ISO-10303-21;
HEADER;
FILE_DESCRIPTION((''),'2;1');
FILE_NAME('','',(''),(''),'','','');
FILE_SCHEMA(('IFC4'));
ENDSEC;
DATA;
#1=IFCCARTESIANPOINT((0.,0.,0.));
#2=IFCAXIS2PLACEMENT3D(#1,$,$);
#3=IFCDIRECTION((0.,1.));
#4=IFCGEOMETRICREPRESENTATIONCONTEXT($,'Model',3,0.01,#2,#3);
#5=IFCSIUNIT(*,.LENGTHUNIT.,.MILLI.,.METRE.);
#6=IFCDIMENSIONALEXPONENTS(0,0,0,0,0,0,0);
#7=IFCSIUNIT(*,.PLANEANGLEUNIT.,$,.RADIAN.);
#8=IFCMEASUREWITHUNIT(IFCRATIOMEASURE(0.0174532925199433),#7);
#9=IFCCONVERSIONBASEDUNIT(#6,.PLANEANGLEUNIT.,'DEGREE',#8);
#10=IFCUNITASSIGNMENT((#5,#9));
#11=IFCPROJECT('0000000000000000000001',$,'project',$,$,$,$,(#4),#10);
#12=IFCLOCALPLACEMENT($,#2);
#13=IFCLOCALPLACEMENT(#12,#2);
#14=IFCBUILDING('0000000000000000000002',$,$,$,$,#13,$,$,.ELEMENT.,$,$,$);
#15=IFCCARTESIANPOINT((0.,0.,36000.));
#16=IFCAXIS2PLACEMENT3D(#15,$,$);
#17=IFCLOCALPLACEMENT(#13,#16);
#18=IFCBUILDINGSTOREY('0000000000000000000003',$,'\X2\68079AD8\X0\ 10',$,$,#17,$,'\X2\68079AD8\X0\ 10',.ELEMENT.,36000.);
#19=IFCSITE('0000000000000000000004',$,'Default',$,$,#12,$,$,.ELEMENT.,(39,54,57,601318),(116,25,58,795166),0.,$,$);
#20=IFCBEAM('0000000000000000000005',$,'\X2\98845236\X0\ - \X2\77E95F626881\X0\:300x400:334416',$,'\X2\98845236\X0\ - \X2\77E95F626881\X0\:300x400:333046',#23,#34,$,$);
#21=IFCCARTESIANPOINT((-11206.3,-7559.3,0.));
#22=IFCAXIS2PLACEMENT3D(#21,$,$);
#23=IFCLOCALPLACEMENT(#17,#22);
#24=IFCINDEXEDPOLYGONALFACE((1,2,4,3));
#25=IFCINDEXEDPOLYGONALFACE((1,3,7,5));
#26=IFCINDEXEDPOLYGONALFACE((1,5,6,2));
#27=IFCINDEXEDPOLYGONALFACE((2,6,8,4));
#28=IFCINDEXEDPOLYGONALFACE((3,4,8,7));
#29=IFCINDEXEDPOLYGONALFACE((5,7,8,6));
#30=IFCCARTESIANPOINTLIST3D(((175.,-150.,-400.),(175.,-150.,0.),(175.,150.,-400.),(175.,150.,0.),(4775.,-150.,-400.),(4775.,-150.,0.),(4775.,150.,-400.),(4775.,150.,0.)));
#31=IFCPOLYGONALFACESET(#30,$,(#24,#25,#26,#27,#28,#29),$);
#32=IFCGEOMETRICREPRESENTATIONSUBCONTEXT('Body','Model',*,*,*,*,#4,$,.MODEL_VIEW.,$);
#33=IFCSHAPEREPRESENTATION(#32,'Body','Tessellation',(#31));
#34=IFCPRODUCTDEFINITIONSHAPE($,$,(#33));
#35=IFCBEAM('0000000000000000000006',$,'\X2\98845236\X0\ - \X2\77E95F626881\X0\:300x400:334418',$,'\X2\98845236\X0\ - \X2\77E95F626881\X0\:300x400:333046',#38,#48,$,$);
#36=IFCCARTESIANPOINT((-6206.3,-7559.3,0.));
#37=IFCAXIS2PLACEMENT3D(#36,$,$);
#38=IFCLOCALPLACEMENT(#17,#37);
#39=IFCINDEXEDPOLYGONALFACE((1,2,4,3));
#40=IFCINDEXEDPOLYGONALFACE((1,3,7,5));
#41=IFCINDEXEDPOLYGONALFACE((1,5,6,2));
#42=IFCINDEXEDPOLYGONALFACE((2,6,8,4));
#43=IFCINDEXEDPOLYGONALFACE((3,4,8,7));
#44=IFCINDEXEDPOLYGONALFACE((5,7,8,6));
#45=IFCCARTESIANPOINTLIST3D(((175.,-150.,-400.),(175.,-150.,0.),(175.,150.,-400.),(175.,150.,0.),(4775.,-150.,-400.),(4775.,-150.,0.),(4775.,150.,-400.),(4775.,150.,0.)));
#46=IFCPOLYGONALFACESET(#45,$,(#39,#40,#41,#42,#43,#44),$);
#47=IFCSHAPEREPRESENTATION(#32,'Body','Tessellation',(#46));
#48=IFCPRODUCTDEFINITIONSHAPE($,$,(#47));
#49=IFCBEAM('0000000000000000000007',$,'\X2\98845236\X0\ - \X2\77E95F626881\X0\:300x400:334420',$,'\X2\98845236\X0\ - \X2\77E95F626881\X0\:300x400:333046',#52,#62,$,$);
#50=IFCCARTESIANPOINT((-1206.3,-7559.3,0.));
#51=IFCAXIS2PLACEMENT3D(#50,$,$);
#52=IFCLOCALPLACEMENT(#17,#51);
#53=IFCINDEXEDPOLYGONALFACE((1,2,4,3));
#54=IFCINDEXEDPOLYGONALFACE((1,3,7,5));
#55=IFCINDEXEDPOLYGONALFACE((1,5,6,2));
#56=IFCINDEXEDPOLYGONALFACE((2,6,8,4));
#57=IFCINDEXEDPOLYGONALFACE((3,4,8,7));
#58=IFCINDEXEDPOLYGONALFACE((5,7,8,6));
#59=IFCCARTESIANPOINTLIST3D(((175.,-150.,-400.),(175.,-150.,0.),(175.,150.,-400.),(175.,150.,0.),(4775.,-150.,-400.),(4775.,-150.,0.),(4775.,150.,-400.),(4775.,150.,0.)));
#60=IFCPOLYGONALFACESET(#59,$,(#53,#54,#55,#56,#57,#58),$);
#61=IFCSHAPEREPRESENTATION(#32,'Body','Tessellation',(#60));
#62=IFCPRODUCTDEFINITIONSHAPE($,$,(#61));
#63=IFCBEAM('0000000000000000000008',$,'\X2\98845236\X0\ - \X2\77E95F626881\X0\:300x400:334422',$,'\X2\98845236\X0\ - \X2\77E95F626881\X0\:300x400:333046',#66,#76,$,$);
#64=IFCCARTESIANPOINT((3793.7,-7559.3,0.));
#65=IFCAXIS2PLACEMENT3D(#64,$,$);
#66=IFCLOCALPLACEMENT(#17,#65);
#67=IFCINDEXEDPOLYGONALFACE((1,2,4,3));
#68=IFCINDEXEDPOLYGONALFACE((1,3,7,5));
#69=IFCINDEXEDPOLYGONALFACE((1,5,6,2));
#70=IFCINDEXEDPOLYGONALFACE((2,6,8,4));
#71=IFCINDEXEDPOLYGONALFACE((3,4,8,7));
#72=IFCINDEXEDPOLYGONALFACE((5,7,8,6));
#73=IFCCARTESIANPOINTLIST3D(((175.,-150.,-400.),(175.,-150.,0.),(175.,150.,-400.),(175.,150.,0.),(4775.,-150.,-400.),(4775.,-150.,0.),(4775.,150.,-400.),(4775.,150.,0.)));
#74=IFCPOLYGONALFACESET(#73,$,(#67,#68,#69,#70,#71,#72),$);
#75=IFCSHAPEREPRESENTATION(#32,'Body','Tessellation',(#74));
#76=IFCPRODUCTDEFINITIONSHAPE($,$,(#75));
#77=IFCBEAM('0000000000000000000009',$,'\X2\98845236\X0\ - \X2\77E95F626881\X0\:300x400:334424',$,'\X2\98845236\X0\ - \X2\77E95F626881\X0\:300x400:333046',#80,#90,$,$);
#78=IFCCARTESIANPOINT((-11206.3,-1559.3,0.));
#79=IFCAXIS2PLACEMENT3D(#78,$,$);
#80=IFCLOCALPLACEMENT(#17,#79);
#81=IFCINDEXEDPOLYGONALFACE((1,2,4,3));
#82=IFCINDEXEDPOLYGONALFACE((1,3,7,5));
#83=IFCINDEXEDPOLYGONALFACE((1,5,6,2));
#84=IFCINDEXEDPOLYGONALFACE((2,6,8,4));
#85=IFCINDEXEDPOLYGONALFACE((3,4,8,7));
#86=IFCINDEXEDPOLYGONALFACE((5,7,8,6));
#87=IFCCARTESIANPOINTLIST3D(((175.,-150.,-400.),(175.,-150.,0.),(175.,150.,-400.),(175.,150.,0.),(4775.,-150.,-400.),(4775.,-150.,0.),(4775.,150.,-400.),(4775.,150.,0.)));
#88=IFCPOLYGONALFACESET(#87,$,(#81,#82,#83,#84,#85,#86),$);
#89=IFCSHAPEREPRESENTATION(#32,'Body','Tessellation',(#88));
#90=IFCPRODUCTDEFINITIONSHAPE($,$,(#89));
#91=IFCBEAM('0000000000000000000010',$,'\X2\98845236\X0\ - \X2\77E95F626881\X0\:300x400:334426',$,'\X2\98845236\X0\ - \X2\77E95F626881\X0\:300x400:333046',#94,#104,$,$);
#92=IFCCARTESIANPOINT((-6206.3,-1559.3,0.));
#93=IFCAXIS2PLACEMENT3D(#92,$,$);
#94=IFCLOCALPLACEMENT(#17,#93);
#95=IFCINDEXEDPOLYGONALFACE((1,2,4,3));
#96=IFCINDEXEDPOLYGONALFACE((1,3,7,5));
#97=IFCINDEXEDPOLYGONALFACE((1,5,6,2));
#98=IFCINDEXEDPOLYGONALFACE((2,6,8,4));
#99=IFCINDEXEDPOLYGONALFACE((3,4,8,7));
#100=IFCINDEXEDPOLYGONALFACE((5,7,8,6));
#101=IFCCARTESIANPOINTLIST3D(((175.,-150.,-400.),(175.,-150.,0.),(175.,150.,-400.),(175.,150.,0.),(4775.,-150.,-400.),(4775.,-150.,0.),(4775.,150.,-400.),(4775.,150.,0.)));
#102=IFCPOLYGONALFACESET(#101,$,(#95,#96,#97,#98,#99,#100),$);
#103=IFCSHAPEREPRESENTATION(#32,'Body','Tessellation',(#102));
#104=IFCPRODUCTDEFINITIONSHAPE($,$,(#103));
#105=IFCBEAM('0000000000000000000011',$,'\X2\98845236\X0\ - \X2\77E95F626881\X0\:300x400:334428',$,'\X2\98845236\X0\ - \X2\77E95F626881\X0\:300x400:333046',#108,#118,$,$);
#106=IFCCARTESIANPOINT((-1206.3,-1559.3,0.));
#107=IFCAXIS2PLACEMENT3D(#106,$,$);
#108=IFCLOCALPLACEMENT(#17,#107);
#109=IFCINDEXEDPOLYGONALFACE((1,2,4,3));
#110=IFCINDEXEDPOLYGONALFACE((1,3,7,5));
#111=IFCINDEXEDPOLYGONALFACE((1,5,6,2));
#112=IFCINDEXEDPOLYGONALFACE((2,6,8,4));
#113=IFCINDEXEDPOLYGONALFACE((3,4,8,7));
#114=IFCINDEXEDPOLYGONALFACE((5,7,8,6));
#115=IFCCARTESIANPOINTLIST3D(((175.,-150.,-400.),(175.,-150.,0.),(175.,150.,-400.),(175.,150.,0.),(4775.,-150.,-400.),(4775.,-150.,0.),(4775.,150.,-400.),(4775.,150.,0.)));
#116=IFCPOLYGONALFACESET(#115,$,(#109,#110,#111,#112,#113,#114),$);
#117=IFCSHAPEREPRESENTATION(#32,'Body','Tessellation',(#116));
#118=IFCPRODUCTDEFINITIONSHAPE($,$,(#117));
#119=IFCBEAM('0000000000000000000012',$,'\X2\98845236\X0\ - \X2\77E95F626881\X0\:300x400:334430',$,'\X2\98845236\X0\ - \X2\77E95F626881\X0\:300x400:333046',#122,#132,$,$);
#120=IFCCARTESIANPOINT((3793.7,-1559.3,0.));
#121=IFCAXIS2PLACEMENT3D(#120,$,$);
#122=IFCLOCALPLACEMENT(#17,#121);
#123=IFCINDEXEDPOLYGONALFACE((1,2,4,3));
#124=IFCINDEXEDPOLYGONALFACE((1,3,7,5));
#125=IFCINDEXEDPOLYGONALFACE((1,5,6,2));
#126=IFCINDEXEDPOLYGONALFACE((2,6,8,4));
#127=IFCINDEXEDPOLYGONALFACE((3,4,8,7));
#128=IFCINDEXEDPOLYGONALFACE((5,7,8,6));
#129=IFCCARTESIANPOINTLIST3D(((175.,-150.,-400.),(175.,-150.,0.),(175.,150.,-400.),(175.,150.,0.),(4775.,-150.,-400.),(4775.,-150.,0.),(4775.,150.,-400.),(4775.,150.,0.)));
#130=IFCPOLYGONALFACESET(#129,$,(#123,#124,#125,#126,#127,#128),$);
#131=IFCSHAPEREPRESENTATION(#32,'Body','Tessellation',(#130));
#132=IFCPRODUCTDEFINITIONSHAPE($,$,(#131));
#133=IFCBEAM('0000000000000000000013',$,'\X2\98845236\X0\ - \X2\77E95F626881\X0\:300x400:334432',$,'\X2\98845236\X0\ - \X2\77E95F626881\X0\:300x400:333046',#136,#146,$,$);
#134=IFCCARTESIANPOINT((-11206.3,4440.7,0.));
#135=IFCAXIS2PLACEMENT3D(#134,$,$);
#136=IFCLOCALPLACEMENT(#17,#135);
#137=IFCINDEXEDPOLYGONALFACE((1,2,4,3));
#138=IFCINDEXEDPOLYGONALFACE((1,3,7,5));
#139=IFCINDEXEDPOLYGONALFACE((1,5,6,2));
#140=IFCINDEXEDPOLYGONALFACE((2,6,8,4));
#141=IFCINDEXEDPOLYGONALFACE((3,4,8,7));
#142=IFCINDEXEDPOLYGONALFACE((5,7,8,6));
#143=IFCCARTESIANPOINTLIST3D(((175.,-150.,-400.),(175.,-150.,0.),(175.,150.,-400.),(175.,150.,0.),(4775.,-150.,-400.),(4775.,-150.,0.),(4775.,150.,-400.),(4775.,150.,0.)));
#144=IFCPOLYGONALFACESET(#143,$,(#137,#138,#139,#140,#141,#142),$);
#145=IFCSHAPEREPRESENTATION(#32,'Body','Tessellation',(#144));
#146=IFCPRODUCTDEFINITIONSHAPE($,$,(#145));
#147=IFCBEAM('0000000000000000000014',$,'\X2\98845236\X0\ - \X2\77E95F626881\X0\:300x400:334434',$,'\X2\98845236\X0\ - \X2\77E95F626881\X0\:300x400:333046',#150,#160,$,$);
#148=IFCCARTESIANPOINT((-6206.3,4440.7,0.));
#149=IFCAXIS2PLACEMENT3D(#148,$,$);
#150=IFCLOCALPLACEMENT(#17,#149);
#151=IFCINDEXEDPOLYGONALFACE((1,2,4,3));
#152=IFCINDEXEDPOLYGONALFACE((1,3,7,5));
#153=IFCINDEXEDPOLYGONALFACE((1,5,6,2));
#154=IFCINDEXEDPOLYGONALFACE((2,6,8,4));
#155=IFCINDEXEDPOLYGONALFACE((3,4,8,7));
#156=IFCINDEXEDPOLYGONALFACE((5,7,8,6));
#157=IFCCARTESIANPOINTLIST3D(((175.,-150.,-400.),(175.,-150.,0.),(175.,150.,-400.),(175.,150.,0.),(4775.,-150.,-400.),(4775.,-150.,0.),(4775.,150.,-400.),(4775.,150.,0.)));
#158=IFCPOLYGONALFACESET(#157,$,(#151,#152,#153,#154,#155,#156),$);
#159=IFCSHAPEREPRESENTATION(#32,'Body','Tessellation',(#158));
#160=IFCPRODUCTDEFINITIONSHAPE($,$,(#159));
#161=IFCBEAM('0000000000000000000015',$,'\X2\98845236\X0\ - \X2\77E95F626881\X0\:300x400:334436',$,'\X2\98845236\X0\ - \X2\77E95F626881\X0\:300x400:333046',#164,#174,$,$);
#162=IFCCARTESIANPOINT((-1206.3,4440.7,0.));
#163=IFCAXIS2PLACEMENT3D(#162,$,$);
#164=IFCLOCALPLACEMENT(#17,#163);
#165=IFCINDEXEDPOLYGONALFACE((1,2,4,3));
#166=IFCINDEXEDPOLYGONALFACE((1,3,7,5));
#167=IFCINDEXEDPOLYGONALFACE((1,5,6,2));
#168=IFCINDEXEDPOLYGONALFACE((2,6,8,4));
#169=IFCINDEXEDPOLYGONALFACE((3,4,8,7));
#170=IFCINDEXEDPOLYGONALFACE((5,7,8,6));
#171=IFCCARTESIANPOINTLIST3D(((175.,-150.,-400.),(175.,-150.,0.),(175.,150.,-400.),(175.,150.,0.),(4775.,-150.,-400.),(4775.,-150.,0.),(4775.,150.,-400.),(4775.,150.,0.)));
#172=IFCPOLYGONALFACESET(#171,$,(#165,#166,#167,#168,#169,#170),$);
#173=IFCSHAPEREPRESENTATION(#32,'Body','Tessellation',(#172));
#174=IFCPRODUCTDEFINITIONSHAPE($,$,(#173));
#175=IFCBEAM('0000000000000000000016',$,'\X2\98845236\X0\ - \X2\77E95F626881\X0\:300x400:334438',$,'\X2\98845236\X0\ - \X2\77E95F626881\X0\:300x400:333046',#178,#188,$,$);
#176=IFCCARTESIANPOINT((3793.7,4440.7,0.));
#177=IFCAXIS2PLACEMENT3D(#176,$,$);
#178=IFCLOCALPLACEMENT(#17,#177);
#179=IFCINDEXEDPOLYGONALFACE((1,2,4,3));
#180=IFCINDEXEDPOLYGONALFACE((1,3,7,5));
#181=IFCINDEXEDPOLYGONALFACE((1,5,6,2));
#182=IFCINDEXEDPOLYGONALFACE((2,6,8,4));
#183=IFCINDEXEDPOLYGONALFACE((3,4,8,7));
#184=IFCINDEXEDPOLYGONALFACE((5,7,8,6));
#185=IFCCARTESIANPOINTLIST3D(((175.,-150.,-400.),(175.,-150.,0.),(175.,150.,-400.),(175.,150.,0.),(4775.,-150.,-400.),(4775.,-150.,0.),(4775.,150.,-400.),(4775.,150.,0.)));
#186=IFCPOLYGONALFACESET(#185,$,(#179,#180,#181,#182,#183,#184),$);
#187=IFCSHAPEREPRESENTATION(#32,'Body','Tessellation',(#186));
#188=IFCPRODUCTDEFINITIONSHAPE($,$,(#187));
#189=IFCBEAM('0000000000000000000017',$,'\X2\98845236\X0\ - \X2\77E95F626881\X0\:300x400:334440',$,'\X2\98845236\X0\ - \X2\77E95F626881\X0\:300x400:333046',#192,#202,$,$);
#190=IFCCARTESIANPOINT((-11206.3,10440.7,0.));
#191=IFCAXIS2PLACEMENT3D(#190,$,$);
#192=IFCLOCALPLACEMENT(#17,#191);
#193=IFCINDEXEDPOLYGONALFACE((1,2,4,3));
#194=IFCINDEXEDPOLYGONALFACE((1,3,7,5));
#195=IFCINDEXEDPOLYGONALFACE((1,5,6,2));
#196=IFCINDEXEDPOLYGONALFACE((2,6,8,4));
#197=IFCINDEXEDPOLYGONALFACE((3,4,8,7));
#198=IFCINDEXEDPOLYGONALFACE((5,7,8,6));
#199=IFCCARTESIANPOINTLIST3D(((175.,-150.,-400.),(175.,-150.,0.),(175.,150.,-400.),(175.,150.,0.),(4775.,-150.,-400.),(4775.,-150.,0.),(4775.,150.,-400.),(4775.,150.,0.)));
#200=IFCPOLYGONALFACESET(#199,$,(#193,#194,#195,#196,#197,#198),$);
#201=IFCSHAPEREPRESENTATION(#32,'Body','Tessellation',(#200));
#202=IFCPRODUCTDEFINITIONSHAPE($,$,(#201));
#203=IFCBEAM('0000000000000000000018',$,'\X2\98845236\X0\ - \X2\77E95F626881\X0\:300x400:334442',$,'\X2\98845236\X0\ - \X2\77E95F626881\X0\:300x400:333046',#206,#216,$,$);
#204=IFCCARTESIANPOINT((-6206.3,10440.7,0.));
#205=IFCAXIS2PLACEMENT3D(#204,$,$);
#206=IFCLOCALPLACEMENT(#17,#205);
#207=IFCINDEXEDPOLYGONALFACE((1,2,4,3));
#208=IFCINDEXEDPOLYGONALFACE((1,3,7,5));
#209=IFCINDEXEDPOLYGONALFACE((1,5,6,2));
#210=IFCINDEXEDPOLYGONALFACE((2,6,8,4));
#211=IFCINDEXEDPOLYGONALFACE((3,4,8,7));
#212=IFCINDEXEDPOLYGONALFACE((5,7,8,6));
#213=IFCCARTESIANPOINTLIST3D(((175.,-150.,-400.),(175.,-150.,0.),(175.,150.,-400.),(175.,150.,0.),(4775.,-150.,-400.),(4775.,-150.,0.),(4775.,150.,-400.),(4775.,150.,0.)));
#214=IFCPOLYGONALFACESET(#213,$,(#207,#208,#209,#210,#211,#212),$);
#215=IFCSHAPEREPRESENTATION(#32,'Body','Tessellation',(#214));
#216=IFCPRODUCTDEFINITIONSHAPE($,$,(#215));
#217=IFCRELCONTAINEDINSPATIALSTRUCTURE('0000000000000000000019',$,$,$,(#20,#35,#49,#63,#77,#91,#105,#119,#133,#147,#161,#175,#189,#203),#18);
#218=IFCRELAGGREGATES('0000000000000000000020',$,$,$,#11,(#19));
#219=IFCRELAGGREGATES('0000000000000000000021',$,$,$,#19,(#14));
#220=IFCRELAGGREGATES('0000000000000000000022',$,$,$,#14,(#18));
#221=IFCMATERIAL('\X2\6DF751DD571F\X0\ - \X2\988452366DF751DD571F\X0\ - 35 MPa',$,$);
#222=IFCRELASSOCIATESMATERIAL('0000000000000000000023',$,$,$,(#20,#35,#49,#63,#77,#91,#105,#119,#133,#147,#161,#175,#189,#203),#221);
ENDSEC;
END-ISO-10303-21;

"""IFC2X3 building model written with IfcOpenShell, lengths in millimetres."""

from ifc_helpers import new_model, entity, si_unit, converted_unit, direction, frame, frame_2d, origin, place, context, subcontext, project, spatial, rectangle, extrude, material, element, save


model = new_model("IFC2X3")

# Units and contexts
model_context = context("Model", 3, precision=0.01, world=origin(), true_north=direction((0.0, 1.0)))
body_context = subcontext(model_context, "Body", "Model", "MODEL_VIEW")
ifc_project = project(units=[si_unit("LENGTHUNIT", "METRE", prefix="MILLI"), converted_unit("PLANEANGLEUNIT", "DEGREE", entity("IfcRatioMeasure", 0.0174532925199433), si_unit("PLANEANGLEUNIT", "RADIAN"), dimensions=[0, 0, 0, 0, 0, 0, 0])], contexts=[model_context])

# Site, building, storey
site_placement = place(None, origin())
site = spatial("IfcSite", under=ifc_project, at=site_placement, Name="Default", CompositionType="ELEMENT", RefLatitude=(39, 54, 57, 601318), RefLongitude=(116, 25, 58, 795166), RefElevation=0.0)
building_placement = place(site_placement, origin())
building = spatial("IfcBuilding", under=site, at=building_placement, CompositionType="ELEMENT")
storey_placement = place(building_placement, frame((0.0, 0.0, 36000.0)))
storey = spatial("IfcBuildingStorey", under=building, at=storey_placement, Name="标高 10", LongName="标高 10", CompositionType="ELEMENT", Elevation=36000.0)

# Beams
ifc_material_1 = material(Name="混凝土 - 预制混凝土 - 35 MPa")
for number, where, name in (
    (1, (-11206.3, -7559.3, 0.0), "预制 - 矩形梁:300x400:334416"),
    (2, (-6206.3, -7559.3, 0.0), "预制 - 矩形梁:300x400:334418"),
):
    element("IfcBeam", number, at=place(storey_placement, frame(where)), inside=storey, material=ifc_material_1, Name=name, ObjectType="预制 - 矩形梁:300x400:333046", context=body_context, shape_type="SweptSolid", body=[
        extrude(rectangle(XDim=400.0, YDim=300.0, at=frame_2d((0.0, 0.0), x_axis=(1.0, 0.0))), frame((175.0, 0.0, -200.0), z_axis=(1.0, 0.0, 0.0), x_axis=(0.0, 0.0, -1.0)), (0.0, 0.0, 1.0), 4600.0),
    ])
for number, where, name in (
    (3, (-1206.3, -7559.3, 0.0), "预制 - 矩形梁:300x400:334420"),
    (4, (3793.7, -7559.3, 0.0), "预制 - 矩形梁:300x400:334422"),
):
    element("IfcBeam", number, at=place(storey_placement, frame(where)), inside=storey, material=ifc_material_1, Name=name, ObjectType="预制 - 矩形梁:300x400:333046", context=body_context, shape_type="SweptSolid", body=[
        extrude(rectangle(XDim=400.0, YDim=300.0, at=frame_2d((0.0, 0.0), x_axis=(1.0, 0.0))), frame((175.0, 0.0, -200.0), z_axis=(1.0, 0.0, 0.0), x_axis=(0.0, 0.0, -1.0)), (0.0, 0.0, 1.0), 4600.0),
    ])
for number, where, name in (
    (5, (-11206.3, -1559.3, 0.0), "预制 - 矩形梁:300x400:334424"),
    (6, (-6206.3, -1559.3, 0.0), "预制 - 矩形梁:300x400:334426"),
    (7, (-1206.3, -1559.3, 0.0), "预制 - 矩形梁:300x400:334428"),
):
    element("IfcBeam", number, at=place(storey_placement, frame(where)), inside=storey, material=ifc_material_1, Name=name, ObjectType="预制 - 矩形梁:300x400:333046", context=body_context, shape_type="SweptSolid", body=[
        extrude(rectangle(XDim=400.0, YDim=300.0, at=frame_2d((0.0, 0.0), x_axis=(1.0, 0.0))), frame((175.0, 0.0, -200.0), z_axis=(1.0, 0.0, 0.0), x_axis=(0.0, 0.0, -1.0)), (0.0, 0.0, 1.0), 4600.0),
    ])
beam_1_placement = place(storey_placement, frame((3793.7, -1559.3, 0.0)))
element("IfcBeam", 8, at=beam_1_placement, inside=storey, material=ifc_material_1, Name="预制 - 矩形梁:300x400:334430", ObjectType="预制 - 矩形梁:300x400:333046", context=body_context, shape_type="SweptSolid", body=[
    extrude(rectangle(XDim=400.0, YDim=300.0, at=frame_2d((0.0, 0.0), x_axis=(1.0, 0.0))), frame((175.0, 0.0, -200.0), z_axis=(1.0, 0.0, 0.0), x_axis=(0.0, 0.0, -1.0)), (0.0, 0.0, 1.0), 4600.0),
])
beam_2_placement = place(storey_placement, frame((-11206.3, 4440.7, 0.0)))
element("IfcBeam", 9, at=beam_2_placement, inside=storey, material=ifc_material_1, Name="预制 - 矩形梁:300x400:334432", ObjectType="预制 - 矩形梁:300x400:333046", context=body_context, shape_type="SweptSolid", body=[
    extrude(rectangle(XDim=400.0, YDim=300.0, at=frame_2d((0.0, 0.0), x_axis=(1.0, 0.0))), frame((175.0, 0.0, -200.0), z_axis=(1.0, 0.0, 0.0), x_axis=(0.0, 0.0, -1.0)), (0.0, 0.0, 1.0), 4600.0),
])
beam_3_placement = place(storey_placement, frame((-6206.3, 4440.7, 0.0)))
element("IfcBeam", 10, at=beam_3_placement, inside=storey, material=ifc_material_1, Name="预制 - 矩形梁:300x400:334434", ObjectType="预制 - 矩形梁:300x400:333046", context=body_context, shape_type="SweptSolid", body=[
    extrude(rectangle(XDim=400.0, YDim=300.0, at=frame_2d((0.0, 0.0), x_axis=(1.0, 0.0))), frame((175.0, 0.0, -200.0), z_axis=(1.0, 0.0, 0.0), x_axis=(0.0, 0.0, -1.0)), (0.0, 0.0, 1.0), 4600.0),
])
beam_4_placement = place(storey_placement, frame((-1206.3, 4440.7, 0.0)))
element("IfcBeam", 11, at=beam_4_placement, inside=storey, material=ifc_material_1, Name="预制 - 矩形梁:300x400:334436", ObjectType="预制 - 矩形梁:300x400:333046", context=body_context, shape_type="SweptSolid", body=[
    extrude(rectangle(XDim=400.0, YDim=300.0, at=frame_2d((0.0, 0.0), x_axis=(1.0, 0.0))), frame((175.0, 0.0, -200.0), z_axis=(1.0, 0.0, 0.0), x_axis=(0.0, 0.0, -1.0)), (0.0, 0.0, 1.0), 4600.0),
])
beam_5_placement = place(storey_placement, frame((3793.7, 4440.7, 0.0)))
element("IfcBeam", 12, at=beam_5_placement, inside=storey, material=ifc_material_1, Name="预制 - 矩形梁:300x400:334438", ObjectType="预制 - 矩形梁:300x400:333046", context=body_context, shape_type="SweptSolid", body=[
    extrude(rectangle(XDim=400.0, YDim=300.0, at=frame_2d((0.0, 0.0), x_axis=(1.0, 0.0))), frame((175.0, 0.0, -200.0), z_axis=(1.0, 0.0, 0.0), x_axis=(0.0, 0.0, -1.0)), (0.0, 0.0, 1.0), 4600.0),
])
beam_6_placement = place(storey_placement, frame((-11206.3, 10440.7, 0.0)))
element("IfcBeam", 13, at=beam_6_placement, inside=storey, material=ifc_material_1, Name="预制 - 矩形梁:300x400:334440", ObjectType="预制 - 矩形梁:300x400:333046", context=body_context, shape_type="SweptSolid", body=[
    extrude(rectangle(XDim=400.0, YDim=300.0, at=frame_2d((0.0, 0.0), x_axis=(1.0, 0.0))), frame((175.0, 0.0, -200.0), z_axis=(1.0, 0.0, 0.0), x_axis=(0.0, 0.0, -1.0)), (0.0, 0.0, 1.0), 4600.0),
])
beam_7_placement = place(storey_placement, frame((-6206.3, 10440.7, 0.0)))
element("IfcBeam", 14, at=beam_7_placement, inside=storey, material=ifc_material_1, Name="预制 - 矩形梁:300x400:334442", ObjectType="预制 - 矩形梁:300x400:333046", context=body_context, shape_type="SweptSolid", body=[
    extrude(rectangle(XDim=400.0, YDim=300.0, at=frame_2d((0.0, 0.0), x_axis=(1.0, 0.0))), frame((175.0, 0.0, -200.0), z_axis=(1.0, 0.0, 0.0), x_axis=(0.0, 0.0, -1.0)), (0.0, 0.0, 1.0), 4600.0),
])

save(model, "model.ifc")
